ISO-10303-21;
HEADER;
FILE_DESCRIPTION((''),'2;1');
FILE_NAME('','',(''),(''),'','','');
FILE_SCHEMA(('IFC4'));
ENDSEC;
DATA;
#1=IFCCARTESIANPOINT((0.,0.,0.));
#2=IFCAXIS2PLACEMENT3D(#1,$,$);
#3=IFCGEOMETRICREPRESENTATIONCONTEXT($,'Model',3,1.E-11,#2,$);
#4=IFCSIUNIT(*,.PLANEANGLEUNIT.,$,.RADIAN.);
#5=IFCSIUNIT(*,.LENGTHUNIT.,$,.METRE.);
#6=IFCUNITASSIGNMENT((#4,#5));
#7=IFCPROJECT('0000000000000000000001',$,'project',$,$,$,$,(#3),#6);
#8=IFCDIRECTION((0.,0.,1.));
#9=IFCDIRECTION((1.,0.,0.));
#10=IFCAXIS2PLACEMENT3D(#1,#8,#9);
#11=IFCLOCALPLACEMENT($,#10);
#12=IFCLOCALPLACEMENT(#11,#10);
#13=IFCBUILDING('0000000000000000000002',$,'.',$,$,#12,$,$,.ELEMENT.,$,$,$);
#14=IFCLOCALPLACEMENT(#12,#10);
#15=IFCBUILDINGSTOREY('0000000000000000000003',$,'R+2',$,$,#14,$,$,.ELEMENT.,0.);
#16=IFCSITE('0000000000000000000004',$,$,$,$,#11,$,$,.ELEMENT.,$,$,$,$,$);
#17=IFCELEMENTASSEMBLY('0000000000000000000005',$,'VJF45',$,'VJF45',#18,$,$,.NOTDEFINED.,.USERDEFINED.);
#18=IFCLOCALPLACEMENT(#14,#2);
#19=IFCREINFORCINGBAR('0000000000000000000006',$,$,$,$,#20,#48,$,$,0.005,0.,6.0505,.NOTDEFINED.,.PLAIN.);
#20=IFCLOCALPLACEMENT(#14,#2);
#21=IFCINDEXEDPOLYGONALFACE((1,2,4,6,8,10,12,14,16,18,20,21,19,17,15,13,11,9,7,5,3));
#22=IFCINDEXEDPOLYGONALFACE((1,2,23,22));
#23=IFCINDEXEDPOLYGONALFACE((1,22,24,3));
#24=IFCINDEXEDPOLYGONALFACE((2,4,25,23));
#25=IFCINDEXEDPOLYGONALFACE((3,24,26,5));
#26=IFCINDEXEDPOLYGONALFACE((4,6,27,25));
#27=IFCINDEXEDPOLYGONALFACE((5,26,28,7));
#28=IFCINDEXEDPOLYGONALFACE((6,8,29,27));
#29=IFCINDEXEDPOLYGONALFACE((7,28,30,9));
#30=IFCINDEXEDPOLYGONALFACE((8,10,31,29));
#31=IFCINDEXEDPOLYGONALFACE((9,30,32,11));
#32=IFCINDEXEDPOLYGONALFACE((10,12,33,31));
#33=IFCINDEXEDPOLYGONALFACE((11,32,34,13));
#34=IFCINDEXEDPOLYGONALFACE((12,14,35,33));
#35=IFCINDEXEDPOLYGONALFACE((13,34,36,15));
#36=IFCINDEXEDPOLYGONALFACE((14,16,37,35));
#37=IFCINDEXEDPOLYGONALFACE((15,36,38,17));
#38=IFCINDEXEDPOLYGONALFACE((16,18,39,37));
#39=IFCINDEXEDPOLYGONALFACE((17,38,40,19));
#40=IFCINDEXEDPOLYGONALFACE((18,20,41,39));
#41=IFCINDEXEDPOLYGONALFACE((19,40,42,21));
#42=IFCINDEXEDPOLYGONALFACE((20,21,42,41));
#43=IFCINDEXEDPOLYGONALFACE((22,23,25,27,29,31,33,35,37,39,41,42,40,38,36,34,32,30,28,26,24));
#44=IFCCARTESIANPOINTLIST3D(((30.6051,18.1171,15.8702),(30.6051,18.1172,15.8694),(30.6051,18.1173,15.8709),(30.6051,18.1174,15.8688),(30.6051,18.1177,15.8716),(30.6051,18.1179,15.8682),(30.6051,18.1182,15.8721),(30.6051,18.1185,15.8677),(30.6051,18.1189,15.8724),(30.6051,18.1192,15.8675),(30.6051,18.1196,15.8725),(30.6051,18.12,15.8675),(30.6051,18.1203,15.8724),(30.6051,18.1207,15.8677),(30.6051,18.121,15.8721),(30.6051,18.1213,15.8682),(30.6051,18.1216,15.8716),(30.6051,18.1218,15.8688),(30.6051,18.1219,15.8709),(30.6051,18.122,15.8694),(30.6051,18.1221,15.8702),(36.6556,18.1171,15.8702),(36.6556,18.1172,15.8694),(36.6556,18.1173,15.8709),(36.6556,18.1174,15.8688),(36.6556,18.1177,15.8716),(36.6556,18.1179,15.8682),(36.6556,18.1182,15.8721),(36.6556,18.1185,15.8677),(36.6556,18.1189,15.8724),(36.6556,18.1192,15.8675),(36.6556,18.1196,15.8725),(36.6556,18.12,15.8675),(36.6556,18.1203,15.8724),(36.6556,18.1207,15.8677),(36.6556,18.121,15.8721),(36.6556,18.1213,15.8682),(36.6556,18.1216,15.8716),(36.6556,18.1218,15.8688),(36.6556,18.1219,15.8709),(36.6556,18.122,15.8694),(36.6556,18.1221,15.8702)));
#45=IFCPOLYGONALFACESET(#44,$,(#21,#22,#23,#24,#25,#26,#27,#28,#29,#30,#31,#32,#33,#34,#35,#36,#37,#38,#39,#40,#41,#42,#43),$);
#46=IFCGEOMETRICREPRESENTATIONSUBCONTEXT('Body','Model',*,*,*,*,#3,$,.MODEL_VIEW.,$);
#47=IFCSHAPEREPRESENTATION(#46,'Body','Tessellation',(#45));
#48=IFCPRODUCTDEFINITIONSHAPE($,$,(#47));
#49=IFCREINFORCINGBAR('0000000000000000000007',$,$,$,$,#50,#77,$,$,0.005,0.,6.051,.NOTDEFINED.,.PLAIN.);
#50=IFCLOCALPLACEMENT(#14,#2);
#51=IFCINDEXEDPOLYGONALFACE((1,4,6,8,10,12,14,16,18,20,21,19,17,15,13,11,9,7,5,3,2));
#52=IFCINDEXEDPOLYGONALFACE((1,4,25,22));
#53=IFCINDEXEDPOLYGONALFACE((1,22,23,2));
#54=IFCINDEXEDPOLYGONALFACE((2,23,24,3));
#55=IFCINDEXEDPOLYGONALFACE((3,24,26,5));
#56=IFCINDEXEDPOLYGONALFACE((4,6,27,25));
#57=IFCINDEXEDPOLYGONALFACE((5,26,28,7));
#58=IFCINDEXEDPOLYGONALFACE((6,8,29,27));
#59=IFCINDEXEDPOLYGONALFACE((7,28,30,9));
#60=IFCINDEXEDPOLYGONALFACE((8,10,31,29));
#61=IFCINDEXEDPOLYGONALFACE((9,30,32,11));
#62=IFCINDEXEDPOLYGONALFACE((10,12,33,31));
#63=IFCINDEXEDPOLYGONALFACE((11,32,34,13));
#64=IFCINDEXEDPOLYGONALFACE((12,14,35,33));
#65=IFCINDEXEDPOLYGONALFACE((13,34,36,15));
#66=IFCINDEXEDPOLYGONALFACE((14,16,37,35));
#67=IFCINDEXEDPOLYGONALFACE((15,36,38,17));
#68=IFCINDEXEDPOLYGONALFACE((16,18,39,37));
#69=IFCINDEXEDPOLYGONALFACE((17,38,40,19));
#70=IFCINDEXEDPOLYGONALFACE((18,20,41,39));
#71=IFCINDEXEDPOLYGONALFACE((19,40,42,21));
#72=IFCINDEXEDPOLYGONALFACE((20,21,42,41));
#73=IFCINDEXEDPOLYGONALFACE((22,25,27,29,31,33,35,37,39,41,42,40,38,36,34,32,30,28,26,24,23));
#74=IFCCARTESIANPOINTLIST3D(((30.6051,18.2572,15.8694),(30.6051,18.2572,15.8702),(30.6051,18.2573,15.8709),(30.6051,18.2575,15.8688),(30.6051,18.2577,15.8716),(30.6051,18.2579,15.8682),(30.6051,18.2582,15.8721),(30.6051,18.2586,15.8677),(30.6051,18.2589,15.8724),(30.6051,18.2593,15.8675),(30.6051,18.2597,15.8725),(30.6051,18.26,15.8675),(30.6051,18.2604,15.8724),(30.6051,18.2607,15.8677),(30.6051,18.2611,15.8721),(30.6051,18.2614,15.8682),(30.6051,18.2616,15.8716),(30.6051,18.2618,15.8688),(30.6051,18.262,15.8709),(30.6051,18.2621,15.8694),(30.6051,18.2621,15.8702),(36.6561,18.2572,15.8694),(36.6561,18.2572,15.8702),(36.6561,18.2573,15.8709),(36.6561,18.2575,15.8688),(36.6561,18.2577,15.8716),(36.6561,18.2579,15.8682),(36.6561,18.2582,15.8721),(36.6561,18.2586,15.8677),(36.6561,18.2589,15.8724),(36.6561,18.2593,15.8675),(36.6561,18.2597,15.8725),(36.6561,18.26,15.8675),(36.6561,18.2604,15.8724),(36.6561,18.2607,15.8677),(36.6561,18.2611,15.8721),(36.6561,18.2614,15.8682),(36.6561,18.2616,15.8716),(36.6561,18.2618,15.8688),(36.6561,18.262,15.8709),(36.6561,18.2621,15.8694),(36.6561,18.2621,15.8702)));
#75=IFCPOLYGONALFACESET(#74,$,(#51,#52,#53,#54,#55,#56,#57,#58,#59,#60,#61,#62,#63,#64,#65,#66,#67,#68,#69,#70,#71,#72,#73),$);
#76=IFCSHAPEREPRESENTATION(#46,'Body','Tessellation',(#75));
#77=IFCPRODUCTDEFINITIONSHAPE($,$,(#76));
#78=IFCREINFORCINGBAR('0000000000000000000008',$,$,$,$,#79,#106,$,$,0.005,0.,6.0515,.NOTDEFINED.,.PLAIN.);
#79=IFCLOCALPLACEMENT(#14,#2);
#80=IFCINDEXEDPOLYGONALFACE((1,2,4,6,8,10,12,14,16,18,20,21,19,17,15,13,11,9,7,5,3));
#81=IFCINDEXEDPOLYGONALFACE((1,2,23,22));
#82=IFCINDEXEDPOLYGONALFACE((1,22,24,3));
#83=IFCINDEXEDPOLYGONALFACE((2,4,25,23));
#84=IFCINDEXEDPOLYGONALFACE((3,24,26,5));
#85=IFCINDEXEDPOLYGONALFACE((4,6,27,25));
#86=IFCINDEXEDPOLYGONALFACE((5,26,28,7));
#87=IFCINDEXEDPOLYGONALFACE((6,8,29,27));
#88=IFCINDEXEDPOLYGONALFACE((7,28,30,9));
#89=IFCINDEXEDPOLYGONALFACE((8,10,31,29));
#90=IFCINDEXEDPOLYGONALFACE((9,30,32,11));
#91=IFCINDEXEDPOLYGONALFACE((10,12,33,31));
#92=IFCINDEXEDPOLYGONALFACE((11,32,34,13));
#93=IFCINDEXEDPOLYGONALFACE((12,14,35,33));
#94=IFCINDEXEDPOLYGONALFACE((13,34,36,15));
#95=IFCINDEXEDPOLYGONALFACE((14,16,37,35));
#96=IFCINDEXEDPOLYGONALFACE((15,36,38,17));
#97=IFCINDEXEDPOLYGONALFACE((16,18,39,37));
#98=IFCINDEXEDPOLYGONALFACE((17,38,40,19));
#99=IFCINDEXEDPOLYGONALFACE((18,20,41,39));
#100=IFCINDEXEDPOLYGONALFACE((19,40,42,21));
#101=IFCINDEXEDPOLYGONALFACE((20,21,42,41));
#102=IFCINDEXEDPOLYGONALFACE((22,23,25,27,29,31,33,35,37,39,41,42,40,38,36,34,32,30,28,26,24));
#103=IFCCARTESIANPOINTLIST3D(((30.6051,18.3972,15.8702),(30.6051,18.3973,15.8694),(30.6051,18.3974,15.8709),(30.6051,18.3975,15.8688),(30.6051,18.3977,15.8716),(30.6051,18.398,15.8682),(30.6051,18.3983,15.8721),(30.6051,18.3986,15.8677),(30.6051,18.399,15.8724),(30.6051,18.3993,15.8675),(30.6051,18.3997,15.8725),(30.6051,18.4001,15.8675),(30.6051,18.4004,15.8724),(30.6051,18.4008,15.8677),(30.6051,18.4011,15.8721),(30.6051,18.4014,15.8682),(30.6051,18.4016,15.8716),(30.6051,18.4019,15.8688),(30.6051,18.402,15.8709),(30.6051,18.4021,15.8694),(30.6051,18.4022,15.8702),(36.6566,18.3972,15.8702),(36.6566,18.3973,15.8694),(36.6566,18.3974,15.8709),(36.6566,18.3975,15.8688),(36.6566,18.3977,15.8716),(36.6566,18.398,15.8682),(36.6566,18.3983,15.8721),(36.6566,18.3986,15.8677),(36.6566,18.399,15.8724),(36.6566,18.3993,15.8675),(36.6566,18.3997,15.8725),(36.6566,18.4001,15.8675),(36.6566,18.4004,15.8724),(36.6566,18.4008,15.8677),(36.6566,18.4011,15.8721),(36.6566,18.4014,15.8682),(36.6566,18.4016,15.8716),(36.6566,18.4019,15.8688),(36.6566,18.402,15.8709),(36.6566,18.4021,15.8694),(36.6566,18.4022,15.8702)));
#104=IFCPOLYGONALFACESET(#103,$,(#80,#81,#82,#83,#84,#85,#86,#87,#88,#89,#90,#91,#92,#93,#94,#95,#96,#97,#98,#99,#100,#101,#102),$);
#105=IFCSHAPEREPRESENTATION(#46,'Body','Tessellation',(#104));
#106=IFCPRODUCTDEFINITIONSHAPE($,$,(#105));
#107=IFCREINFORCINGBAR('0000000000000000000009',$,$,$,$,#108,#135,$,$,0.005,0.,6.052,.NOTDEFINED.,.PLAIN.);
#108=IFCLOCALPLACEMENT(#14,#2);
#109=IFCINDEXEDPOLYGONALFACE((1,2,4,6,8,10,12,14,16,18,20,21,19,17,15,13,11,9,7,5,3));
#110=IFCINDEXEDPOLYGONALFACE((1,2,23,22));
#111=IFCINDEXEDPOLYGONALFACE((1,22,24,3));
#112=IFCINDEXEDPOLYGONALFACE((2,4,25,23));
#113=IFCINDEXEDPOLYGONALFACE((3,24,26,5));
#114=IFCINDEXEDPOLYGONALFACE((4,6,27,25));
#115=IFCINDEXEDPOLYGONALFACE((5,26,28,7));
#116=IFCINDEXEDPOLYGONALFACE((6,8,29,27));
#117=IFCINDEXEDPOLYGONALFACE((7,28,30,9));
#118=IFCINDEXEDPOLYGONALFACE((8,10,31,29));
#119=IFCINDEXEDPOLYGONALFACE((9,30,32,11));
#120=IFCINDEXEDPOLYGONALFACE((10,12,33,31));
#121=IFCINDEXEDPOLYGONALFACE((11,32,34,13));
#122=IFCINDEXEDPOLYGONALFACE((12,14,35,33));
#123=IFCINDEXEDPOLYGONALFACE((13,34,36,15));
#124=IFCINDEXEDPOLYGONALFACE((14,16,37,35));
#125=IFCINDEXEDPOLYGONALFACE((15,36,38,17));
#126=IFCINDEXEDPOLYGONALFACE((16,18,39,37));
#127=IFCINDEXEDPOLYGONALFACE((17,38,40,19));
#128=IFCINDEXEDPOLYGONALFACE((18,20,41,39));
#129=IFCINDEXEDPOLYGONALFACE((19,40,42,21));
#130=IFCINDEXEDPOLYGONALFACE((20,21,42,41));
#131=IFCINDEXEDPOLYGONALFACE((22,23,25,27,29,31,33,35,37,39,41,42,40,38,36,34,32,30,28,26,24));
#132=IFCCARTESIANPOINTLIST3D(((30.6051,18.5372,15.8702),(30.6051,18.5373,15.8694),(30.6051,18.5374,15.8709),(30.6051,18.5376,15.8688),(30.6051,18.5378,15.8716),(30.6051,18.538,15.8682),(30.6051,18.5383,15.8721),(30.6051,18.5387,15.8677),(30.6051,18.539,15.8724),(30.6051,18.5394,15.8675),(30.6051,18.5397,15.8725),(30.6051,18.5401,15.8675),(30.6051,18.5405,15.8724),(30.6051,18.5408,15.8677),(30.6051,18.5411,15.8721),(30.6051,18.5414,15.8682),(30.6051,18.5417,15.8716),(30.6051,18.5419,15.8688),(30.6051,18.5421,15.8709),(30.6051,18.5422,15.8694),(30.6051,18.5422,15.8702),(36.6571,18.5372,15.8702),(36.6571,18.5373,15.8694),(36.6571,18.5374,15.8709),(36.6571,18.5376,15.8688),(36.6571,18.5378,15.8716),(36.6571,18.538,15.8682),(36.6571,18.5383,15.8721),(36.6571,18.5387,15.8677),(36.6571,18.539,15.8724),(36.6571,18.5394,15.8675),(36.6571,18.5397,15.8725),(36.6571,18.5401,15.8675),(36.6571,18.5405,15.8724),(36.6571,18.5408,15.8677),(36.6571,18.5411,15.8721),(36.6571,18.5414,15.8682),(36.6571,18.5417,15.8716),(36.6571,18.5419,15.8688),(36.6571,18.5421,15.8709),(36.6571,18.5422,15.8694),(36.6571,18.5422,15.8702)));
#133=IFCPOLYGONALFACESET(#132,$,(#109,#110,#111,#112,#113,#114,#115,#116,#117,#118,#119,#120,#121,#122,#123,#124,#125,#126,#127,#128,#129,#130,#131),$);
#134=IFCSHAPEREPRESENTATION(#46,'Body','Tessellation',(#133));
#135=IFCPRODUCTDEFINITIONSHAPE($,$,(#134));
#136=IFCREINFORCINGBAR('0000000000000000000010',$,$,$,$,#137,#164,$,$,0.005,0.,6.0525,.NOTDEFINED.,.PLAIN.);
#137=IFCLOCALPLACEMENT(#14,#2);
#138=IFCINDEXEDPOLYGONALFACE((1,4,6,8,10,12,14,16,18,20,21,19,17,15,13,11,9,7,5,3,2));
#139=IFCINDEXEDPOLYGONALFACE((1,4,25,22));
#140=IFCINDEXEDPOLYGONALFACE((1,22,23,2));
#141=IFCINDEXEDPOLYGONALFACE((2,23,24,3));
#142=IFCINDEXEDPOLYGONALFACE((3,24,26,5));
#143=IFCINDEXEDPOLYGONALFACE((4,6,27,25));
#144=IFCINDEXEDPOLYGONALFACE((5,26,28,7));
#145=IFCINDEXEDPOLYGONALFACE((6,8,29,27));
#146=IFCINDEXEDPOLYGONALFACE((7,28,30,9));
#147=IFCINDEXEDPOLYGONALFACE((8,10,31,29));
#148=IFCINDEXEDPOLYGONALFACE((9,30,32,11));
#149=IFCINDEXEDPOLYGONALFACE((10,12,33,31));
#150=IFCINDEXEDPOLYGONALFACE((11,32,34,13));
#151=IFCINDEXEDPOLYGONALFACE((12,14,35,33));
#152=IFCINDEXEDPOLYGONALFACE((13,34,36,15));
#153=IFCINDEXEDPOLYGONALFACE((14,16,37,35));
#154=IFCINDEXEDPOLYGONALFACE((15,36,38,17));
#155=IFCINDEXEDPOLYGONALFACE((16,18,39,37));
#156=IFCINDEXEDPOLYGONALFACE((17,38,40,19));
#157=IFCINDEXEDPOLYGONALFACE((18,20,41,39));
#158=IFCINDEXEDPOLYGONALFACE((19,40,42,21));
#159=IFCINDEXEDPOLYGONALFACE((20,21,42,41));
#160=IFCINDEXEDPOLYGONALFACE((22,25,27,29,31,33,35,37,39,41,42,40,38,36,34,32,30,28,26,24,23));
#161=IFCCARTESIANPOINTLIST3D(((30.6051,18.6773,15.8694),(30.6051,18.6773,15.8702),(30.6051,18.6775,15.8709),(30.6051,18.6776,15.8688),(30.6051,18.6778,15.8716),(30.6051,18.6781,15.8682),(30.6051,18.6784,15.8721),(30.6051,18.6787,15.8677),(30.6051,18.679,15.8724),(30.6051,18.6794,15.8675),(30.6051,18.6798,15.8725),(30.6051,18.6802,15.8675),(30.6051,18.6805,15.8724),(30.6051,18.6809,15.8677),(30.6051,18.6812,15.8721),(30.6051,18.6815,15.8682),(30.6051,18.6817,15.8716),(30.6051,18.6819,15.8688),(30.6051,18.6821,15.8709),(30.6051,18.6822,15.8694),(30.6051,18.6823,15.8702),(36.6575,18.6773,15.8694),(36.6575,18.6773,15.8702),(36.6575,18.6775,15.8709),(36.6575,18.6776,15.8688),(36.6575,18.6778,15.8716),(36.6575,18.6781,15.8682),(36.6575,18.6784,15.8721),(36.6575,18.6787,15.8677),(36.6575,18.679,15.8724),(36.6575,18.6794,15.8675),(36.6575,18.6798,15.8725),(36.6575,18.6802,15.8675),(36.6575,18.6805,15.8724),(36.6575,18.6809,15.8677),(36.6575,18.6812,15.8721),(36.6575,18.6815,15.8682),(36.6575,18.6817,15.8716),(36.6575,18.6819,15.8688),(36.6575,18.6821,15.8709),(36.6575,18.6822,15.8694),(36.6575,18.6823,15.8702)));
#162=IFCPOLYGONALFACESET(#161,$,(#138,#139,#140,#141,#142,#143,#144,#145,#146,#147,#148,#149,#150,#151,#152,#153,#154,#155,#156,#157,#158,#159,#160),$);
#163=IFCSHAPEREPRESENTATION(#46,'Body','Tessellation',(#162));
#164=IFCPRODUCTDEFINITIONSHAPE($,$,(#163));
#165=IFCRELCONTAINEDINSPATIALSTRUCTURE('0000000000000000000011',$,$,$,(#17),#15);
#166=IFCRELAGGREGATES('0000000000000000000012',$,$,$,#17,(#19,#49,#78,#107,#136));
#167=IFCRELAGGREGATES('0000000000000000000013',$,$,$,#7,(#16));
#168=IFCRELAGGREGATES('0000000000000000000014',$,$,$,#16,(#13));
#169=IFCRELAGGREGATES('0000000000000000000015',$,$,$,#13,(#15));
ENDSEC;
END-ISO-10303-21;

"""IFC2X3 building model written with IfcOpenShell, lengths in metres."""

from ifc_helpers import new_model, entity, si_unit, origin, origin_with_axes, place, context, subcontext, project, spatial, shape, element, aggregate, save


model = new_model("IFC2X3")

# Units and contexts
model_context = context("Model", 3, precision=1e-11, world=origin())
body_context = subcontext(model_context, "Body", "Model", "MODEL_VIEW")
ifc_project = project(units=[si_unit("PLANEANGLEUNIT", "RADIAN"), si_unit("LENGTHUNIT", "METRE")], contexts=[model_context])

# Site, building, storey
site_placement = place(None, origin_with_axes())
site = spatial("IfcSite", under=ifc_project, at=site_placement, CompositionType="ELEMENT")
building_placement = place(site_placement, origin_with_axes())
building = spatial("IfcBuilding", under=site, at=building_placement, Name=".", CompositionType="ELEMENT")
storey_placement = place(building_placement, origin_with_axes())
storey = spatial("IfcBuildingStorey", under=building, at=storey_placement, Name="R+2", CompositionType="ELEMENT", Elevation=0.0)

# Element assembly, reinforcing bars
assembly_1_placement = place(storey_placement, origin_with_axes())
assembly_1 = element("IfcElementAssembly", 1, at=assembly_1_placement, inside=storey, Name="VJF45", ObjectType="VJF45", AssemblyPlace="NOTDEFINED", PredefinedType="USERDEFINED")
reinforcing_bar_1_placement = place(assembly_1_placement, origin_with_axes())
reinforcing_bar_1 = element("IfcReinforcingBar", 2, at=reinforcing_bar_1_placement, BarLength=6.0505, BarRole="NOTDEFINED", BarSurface="PLAIN", CrossSectionArea=0.0, NominalDiameter=0.005, shapes=[
    shape(body_context, "Body", "AdvancedSweptSolid", [entity("IfcSweptDiskSolid", entity("IfcPolyline", [entity("IfcCartesianPoint", [30.6051, 18.1196, 15.87]), entity("IfcCartesianPoint", [36.6556, 18.1196, 15.87])]), 0.0025, None, 0.0, 6.0505)]),
    shape(body_context, "Body", "AdvancedSweptSolid", [entity("IfcSweptDiskSolid", entity("IfcPolyline", [entity("IfcCartesianPoint", [30.6051, 18.1196, 15.87]), entity("IfcCartesianPoint", [36.6556, 18.1196, 15.87])]), 0.0025, None, 0.0, 6.0505)]),
])
reinforcing_bar_2_placement = place(assembly_1_placement, origin_with_axes())
reinforcing_bar_2 = element("IfcReinforcingBar", 3, at=reinforcing_bar_2_placement, BarLength=6.051, BarRole="NOTDEFINED", BarSurface="PLAIN", CrossSectionArea=0.0, NominalDiameter=0.005, shapes=[
    shape(body_context, "Body", "AdvancedSweptSolid", [entity("IfcSweptDiskSolid", entity("IfcPolyline", [entity("IfcCartesianPoint", [30.6051, 18.2597, 15.87]), entity("IfcCartesianPoint", [36.6561, 18.2597, 15.87])]), 0.0025, None, 0.0, 6.051)]),
    shape(body_context, "Body", "AdvancedSweptSolid", [entity("IfcSweptDiskSolid", entity("IfcPolyline", [entity("IfcCartesianPoint", [30.6051, 18.2597, 15.87]), entity("IfcCartesianPoint", [36.6561, 18.2597, 15.87])]), 0.0025, None, 0.0, 6.051)]),
])
reinforcing_bar_3_placement = place(assembly_1_placement, origin_with_axes())
reinforcing_bar_3 = element("IfcReinforcingBar", 4, at=reinforcing_bar_3_placement, BarLength=6.0515, BarRole="NOTDEFINED", BarSurface="PLAIN", CrossSectionArea=0.0, NominalDiameter=0.005, shapes=[
    shape(body_context, "Body", "AdvancedSweptSolid", [entity("IfcSweptDiskSolid", entity("IfcPolyline", [entity("IfcCartesianPoint", [30.6051, 18.3997, 15.87]), entity("IfcCartesianPoint", [36.6566, 18.3997, 15.87])]), 0.0025, None, 0.0, 6.0515)]),
    shape(body_context, "Body", "AdvancedSweptSolid", [entity("IfcSweptDiskSolid", entity("IfcPolyline", [entity("IfcCartesianPoint", [30.6051, 18.3997, 15.87]), entity("IfcCartesianPoint", [36.6566, 18.3997, 15.87])]), 0.0025, None, 0.0, 6.0515)]),
])
reinforcing_bar_4_placement = place(assembly_1_placement, origin_with_axes())
reinforcing_bar_4 = element("IfcReinforcingBar", 5, at=reinforcing_bar_4_placement, BarLength=6.052, BarRole="NOTDEFINED", BarSurface="PLAIN", CrossSectionArea=0.0, NominalDiameter=0.005, shapes=[
    shape(body_context, "Body", "AdvancedSweptSolid", [entity("IfcSweptDiskSolid", entity("IfcPolyline", [entity("IfcCartesianPoint", [30.6051, 18.5397, 15.87]), entity("IfcCartesianPoint", [36.6571, 18.5397, 15.87])]), 0.0025, None, 0.0, 6.052)]),
    shape(body_context, "Body", "AdvancedSweptSolid", [entity("IfcSweptDiskSolid", entity("IfcPolyline", [entity("IfcCartesianPoint", [30.6051, 18.5397, 15.87]), entity("IfcCartesianPoint", [36.6571, 18.5397, 15.87])]), 0.0025, None, 0.0, 6.052)]),
])
reinforcing_bar_5_placement = place(assembly_1_placement, origin_with_axes())
reinforcing_bar_5 = element("IfcReinforcingBar", 6, at=reinforcing_bar_5_placement, BarLength=6.0525, BarRole="NOTDEFINED", BarSurface="PLAIN", CrossSectionArea=0.0, NominalDiameter=0.005, shapes=[
    shape(body_context, "Body", "AdvancedSweptSolid", [entity("IfcSweptDiskSolid", entity("IfcPolyline", [entity("IfcCartesianPoint", [30.6051, 18.6798, 15.87]), entity("IfcCartesianPoint", [36.6575, 18.6798, 15.87])]), 0.0025, None, 0.0, 6.0525)]),
    shape(body_context, "Body", "AdvancedSweptSolid", [entity("IfcSweptDiskSolid", entity("IfcPolyline", [entity("IfcCartesianPoint", [30.6051, 18.6798, 15.87]), entity("IfcCartesianPoint", [36.6575, 18.6798, 15.87])]), 0.0025, None, 0.0, 6.0525)]),
])
aggregate(assembly_1, [reinforcing_bar_1, reinforcing_bar_2, reinforcing_bar_3, reinforcing_bar_4, reinforcing_bar_5])

save(model, "model.ifc")
